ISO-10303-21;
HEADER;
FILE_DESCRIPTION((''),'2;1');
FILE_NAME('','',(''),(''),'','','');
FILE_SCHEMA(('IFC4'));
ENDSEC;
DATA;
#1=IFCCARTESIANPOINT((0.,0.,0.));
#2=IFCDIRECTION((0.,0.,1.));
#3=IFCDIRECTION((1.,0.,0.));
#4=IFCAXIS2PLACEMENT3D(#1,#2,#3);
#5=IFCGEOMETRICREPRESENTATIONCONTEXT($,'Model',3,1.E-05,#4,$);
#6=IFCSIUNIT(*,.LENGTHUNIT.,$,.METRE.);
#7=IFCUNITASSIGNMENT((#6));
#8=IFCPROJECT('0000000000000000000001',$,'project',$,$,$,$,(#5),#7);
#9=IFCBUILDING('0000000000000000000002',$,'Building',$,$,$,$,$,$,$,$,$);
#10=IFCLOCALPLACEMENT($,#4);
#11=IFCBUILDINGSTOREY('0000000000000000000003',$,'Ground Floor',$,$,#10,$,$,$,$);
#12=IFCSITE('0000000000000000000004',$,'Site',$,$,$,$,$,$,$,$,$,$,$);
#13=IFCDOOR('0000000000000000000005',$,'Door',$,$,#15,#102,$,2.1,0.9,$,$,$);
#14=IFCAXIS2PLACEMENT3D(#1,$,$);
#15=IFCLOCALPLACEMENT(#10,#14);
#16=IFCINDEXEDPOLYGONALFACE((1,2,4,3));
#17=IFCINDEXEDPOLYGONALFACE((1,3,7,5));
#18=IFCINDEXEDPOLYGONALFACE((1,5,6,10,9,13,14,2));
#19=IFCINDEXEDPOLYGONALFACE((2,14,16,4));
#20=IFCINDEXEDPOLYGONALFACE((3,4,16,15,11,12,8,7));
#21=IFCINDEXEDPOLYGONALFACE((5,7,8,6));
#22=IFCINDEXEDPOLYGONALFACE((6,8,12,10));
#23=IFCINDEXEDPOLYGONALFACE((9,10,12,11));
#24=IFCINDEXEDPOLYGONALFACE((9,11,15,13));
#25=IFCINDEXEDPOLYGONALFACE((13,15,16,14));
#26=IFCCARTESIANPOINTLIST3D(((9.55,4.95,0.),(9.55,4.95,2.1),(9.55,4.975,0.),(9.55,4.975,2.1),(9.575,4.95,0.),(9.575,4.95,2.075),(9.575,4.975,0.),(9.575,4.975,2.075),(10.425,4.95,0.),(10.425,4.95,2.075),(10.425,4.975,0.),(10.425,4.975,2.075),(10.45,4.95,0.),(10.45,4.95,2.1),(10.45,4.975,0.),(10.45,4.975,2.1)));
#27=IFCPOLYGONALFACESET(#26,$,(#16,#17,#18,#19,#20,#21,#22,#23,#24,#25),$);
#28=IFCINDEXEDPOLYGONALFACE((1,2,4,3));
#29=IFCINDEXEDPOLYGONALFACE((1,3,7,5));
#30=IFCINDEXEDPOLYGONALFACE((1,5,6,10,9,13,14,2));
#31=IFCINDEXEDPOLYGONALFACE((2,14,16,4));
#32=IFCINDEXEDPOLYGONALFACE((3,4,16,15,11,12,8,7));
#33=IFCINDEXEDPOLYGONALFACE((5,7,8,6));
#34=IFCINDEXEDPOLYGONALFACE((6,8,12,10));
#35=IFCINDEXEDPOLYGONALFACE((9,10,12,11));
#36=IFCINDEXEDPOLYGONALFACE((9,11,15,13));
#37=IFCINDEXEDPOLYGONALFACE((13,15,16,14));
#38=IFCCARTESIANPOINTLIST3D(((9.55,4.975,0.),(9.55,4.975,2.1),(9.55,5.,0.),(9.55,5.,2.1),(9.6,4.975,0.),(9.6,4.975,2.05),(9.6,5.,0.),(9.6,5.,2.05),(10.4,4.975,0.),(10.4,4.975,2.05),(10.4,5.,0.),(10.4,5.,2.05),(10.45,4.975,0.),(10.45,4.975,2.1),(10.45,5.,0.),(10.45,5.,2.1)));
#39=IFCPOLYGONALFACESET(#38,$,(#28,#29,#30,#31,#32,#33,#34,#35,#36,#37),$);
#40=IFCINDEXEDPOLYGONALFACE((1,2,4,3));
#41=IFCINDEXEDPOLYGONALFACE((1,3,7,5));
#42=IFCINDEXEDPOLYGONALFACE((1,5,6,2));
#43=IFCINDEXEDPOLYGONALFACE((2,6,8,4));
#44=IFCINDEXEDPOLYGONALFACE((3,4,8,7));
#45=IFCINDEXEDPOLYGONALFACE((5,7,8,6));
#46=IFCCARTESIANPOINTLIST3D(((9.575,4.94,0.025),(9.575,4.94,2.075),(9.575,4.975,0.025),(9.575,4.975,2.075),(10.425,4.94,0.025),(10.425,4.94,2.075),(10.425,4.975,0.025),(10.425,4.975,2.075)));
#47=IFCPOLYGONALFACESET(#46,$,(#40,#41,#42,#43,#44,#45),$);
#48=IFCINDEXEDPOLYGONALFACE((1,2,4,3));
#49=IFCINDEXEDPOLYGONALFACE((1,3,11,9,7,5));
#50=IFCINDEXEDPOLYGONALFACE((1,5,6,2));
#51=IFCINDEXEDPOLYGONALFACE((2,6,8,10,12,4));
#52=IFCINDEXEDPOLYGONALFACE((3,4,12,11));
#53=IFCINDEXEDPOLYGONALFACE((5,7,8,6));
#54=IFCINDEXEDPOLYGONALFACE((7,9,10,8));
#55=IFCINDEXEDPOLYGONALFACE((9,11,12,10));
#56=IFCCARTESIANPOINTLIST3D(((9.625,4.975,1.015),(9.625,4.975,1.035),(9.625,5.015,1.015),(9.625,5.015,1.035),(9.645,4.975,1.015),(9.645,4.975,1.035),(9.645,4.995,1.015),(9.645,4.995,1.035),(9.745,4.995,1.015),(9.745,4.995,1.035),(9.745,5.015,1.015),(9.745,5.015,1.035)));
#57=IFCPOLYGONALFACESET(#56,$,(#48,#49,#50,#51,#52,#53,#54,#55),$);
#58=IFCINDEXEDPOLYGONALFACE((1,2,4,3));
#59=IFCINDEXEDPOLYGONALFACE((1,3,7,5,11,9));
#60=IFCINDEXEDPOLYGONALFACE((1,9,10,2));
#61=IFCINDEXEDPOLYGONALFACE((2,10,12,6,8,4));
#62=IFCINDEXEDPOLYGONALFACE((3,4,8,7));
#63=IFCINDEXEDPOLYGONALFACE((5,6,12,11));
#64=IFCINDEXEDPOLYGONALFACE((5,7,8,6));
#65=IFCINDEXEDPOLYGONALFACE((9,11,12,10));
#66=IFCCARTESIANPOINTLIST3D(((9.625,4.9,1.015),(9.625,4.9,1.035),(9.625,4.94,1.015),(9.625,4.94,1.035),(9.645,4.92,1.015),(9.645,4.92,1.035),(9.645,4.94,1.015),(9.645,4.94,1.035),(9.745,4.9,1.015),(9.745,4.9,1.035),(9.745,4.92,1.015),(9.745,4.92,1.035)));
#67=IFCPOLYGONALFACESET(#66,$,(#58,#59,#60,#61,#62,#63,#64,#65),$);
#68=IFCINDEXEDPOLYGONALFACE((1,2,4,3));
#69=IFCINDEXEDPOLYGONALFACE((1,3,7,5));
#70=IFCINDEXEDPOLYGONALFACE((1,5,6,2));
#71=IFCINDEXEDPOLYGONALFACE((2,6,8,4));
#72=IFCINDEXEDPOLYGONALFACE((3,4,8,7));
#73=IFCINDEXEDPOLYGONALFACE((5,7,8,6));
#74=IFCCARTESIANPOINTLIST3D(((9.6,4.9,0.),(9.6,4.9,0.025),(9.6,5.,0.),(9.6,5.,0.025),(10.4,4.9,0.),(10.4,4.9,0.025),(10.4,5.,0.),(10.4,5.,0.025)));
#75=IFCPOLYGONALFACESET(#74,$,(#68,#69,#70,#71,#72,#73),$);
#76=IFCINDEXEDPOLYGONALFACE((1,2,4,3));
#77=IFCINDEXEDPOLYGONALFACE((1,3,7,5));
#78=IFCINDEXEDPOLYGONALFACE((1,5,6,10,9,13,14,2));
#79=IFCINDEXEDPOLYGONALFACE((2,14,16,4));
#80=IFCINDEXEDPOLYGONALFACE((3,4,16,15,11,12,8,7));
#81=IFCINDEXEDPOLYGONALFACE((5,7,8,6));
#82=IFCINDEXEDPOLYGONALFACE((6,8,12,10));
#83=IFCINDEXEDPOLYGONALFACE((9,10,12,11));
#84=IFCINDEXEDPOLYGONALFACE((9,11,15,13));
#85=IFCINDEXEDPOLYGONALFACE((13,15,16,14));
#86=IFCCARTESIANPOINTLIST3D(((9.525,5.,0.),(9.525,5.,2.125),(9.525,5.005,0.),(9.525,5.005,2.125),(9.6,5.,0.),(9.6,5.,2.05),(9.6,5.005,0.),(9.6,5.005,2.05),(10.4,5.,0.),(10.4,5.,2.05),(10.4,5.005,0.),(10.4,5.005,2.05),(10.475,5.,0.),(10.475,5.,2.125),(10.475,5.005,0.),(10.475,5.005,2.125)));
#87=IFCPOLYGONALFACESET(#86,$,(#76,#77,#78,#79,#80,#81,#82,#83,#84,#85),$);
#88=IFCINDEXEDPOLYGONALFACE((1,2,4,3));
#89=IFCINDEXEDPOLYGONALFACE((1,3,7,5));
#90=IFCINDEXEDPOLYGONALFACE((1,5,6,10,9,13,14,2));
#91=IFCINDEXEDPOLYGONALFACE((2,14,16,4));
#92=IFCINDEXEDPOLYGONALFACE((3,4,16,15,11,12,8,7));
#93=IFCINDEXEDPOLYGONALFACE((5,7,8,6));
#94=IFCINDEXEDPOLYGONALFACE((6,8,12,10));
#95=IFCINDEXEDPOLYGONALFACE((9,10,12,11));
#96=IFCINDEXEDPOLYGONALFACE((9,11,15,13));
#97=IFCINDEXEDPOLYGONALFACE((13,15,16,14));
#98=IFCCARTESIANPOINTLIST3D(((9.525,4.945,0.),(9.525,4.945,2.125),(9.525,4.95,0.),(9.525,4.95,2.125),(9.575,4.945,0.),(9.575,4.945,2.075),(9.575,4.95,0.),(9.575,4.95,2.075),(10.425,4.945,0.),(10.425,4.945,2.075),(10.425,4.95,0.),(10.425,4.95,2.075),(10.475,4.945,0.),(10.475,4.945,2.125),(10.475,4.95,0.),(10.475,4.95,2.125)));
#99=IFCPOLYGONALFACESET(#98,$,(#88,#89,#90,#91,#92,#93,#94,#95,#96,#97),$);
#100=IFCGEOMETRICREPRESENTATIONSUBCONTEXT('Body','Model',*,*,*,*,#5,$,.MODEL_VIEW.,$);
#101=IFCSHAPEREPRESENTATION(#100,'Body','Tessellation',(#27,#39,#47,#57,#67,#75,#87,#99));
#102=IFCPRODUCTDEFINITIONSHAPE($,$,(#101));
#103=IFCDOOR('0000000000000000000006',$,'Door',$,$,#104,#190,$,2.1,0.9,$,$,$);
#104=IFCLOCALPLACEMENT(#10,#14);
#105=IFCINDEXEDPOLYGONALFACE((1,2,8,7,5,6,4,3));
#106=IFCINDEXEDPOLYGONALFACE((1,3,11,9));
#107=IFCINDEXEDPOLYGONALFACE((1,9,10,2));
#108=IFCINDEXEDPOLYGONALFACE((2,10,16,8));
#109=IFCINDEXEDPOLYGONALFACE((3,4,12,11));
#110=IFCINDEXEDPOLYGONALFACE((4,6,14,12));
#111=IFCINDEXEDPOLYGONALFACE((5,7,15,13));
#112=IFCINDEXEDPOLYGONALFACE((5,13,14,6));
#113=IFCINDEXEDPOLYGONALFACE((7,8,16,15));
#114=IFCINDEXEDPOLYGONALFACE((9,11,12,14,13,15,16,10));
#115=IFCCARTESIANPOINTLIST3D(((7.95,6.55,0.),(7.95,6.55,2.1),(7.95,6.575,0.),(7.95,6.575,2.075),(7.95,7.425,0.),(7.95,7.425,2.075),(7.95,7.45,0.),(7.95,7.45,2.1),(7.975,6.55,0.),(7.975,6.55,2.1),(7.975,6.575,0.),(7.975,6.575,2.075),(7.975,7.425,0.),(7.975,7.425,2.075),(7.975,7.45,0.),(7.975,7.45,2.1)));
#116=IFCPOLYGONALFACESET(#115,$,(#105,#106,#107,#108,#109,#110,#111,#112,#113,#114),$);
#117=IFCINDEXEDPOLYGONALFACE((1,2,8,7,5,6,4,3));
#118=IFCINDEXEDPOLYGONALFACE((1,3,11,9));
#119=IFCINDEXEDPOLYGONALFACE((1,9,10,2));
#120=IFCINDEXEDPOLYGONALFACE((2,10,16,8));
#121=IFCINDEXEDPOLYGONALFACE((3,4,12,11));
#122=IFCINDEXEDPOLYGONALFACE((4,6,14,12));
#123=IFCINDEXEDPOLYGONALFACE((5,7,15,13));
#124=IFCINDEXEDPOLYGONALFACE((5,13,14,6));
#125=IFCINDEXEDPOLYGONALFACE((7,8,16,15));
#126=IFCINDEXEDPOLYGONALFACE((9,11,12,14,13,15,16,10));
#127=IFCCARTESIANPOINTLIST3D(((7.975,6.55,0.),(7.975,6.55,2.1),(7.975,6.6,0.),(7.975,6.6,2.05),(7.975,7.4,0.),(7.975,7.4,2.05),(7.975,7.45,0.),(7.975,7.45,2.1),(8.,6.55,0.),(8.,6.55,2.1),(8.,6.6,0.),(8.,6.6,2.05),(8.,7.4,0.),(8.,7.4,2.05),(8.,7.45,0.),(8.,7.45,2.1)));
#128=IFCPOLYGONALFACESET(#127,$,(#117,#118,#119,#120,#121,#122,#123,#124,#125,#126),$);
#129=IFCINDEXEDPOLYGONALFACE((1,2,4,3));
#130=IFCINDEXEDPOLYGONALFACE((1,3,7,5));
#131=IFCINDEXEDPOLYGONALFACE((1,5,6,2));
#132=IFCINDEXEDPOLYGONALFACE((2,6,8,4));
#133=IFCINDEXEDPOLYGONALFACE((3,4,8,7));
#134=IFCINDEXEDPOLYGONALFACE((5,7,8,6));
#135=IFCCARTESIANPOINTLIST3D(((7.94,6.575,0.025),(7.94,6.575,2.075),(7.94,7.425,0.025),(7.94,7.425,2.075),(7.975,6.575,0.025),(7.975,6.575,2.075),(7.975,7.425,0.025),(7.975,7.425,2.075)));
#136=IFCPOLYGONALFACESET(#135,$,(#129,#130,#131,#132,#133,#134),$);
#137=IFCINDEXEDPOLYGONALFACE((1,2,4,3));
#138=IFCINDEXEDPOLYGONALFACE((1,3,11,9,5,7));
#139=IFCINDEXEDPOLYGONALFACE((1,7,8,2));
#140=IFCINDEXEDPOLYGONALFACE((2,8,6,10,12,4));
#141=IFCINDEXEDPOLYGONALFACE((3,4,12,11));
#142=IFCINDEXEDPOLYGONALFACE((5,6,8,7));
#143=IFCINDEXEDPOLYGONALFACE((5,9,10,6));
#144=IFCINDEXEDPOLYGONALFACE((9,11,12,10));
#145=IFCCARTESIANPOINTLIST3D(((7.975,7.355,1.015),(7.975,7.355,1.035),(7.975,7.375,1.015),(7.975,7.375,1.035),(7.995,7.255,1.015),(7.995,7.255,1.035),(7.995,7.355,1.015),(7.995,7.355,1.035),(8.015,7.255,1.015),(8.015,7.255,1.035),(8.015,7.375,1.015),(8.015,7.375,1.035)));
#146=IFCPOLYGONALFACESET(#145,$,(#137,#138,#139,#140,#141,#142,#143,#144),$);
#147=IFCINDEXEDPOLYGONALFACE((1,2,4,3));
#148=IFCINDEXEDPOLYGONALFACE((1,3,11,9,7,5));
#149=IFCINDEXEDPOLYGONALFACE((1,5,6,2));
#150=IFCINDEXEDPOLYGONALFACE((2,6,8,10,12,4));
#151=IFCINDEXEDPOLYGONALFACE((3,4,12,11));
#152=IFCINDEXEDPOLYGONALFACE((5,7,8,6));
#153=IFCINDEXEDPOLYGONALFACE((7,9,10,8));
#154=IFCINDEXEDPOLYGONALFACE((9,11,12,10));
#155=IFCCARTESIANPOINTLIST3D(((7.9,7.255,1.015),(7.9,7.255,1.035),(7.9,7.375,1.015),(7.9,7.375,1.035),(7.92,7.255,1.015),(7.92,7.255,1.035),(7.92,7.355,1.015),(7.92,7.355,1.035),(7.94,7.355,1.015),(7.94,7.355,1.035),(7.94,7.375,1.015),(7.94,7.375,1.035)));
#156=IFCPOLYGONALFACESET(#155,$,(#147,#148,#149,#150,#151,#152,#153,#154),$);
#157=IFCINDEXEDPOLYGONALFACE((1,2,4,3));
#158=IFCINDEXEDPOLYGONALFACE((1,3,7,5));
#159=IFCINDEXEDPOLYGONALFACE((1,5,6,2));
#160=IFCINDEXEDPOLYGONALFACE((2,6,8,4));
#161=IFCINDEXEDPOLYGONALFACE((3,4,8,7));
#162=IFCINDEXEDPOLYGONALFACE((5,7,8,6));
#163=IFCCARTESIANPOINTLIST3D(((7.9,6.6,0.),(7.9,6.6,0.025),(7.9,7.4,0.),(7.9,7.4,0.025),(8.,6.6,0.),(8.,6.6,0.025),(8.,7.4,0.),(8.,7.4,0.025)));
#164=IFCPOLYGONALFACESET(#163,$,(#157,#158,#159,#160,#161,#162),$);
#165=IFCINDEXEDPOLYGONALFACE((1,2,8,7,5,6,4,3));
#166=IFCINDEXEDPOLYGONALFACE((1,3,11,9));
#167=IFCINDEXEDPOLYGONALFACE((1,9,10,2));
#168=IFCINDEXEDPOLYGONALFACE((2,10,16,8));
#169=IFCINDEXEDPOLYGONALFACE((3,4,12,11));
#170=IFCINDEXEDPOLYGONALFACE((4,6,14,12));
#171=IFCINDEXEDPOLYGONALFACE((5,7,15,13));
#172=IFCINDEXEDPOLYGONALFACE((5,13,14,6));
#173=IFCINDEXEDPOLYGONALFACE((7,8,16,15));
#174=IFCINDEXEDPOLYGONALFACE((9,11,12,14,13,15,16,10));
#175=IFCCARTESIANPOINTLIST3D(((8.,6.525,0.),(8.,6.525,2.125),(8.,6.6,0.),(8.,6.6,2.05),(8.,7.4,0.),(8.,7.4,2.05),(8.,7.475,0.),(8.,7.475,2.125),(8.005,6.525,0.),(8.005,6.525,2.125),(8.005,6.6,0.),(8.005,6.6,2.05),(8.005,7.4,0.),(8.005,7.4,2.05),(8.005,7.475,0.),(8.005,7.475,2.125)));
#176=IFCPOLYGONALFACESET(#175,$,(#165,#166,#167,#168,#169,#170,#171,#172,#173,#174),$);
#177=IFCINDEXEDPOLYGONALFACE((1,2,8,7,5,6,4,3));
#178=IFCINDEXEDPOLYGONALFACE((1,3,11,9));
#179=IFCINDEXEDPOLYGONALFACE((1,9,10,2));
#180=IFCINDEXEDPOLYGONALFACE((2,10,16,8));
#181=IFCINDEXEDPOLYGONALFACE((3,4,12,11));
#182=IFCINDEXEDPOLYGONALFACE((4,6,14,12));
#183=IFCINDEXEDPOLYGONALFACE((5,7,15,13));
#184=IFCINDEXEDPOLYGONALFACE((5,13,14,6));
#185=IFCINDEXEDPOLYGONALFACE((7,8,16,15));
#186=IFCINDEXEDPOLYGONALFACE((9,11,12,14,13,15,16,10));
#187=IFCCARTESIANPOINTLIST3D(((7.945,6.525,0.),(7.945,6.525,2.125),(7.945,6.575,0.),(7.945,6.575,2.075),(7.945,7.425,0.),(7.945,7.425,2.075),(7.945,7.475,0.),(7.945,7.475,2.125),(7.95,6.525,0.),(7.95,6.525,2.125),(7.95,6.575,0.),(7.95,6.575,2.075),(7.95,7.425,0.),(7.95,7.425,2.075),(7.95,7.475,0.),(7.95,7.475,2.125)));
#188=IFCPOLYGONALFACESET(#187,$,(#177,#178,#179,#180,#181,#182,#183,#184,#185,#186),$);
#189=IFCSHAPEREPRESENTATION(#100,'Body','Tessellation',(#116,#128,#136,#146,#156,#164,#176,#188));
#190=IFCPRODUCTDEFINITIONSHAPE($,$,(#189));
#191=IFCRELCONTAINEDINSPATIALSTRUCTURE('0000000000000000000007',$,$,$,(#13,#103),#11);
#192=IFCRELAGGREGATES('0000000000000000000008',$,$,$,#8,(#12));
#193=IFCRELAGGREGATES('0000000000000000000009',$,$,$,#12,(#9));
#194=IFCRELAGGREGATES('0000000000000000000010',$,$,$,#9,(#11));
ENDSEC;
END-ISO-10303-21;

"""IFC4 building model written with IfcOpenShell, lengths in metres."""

from ifc_helpers import new_model, si_unit, frame, origin_with_axes, place, context, subcontext, project, spatial, line, indexed_curve, outline, extrude, element, save


model = new_model("IFC4")

# Units and contexts
model_context = context("Model", 3, precision=1e-05, world=origin_with_axes())
body_context = subcontext(model_context, "Body", "Model", "MODEL_VIEW")
ifc_project = project(units=[si_unit("LENGTHUNIT", "METRE")], contexts=[model_context])

# Site, building, storey
site = spatial("IfcSite", under=ifc_project, Name="Site")
building = spatial("IfcBuilding", under=site, Name="Building")
storey_placement = place(None, origin_with_axes())
storey = spatial("IfcBuildingStorey", under=building, at=storey_placement, Name="Ground Floor")

# Doors
door_1_placement = place(storey_placement, frame((10.45, 5.0, 0.0), z_axis=(0.0, 0.0, 1.0), x_axis=(-1.0, 0.0, 0.0)))
element("IfcDoor", 1, at=door_1_placement, inside=storey, Name="Door", OverallHeight=2.1, OverallWidth=0.9, context=body_context, shape_type="SweptSolid", body=[
    extrude(outline(indexed_curve([(0.0, 0.0), (0.0, 2.1), (0.9, 2.1), (0.9, 0.0), (0.875, 0.0), (0.875, 2.075), (0.025, 2.075), (0.025, 0.0)], segments=[line(1, 2, 3, 4, 5, 6, 7, 8, 1)])), frame((0.0, 0.025, 0.0), z_axis=(0.0, -1.0, 0.0), x_axis=(1.0, 0.0, 0.0)), (0.0, 0.0, -1.0), 0.025),
    extrude(outline(indexed_curve([(0.0, 0.0), (0.0, 2.1), (0.9, 2.1), (0.9, 0.0), (0.85, 0.0), (0.85, 2.05), (0.05, 2.05), (0.05, 0.0)], segments=[line(1, 2, 3, 4, 5, 6, 7, 8, 1)])), frame((0.0, 0.0, 0.0), z_axis=(0.0, -1.0, 0.0), x_axis=(1.0, 0.0, 0.0)), (0.0, 0.0, -1.0), 0.025),
    extrude(outline(indexed_curve([(0.0, 0.0), (0.85, 0.0), (0.85, 0.035), (0.0, 0.035)], segments=[line(1, 2, 3, 4, 1)])), frame((0.025, 0.025, 0.025), z_axis=(0.0, 0.0, 1.0), x_axis=(1.0, 0.0, 0.0)), (0.0, 0.0, 1.0), 2.05),
    extrude(outline(indexed_curve([(0.0, 0.0), (0.0, -0.04), (-0.12, -0.04), (-0.12, -0.02), (-0.02, -0.02), (-0.02, 0.0)], segments=[line(1, 2, 3, 4, 5, 6, 1)])), frame((0.825, 0.025, 1.015), z_axis=(0.0, 0.0, 1.0), x_axis=(1.0, 0.0, 0.0)), (0.0, 0.0, 1.0), 0.02),
    extrude(outline(indexed_curve([(0.0, 0.0), (0.0, 0.04), (-0.12, 0.04), (-0.12, 0.02), (-0.02, 0.02), (-0.02, 0.0)], segments=[line(1, 2, 3, 4, 5, 6, 1)])), frame((0.825, 0.06, 1.015), z_axis=(0.0, 0.0, 1.0), x_axis=(1.0, 0.0, 0.0)), (0.0, 0.0, 1.0), 0.02),
    extrude(outline(indexed_curve([(0.0, 0.0), (0.8, 0.0), (0.8, 0.1), (0.0, 0.1)], segments=[line(1, 2, 3, 4, 1)])), frame((0.05, 0.0, 0.0), z_axis=(0.0, 0.0, 1.0), x_axis=(1.0, 0.0, 0.0)), (0.0, 0.0, 1.0), 0.025),
    extrude(outline(indexed_curve([(0.0, 0.0), (0.0, 2.125), (0.95, 2.125), (0.95, 0.0), (0.875, 0.0), (0.875, 2.05), (0.075, 2.05), (0.075, 0.0)], segments=[line(1, 2, 3, 4, 5, 6, 7, 8, 1)])), frame((-0.025, -0.005, 0.0), z_axis=(0.0, -1.0, 0.0), x_axis=(1.0, 0.0, 0.0)), (0.0, 0.0, -1.0), 0.005),
    extrude(outline(indexed_curve([(0.0, 0.0), (0.0, 2.125), (0.95, 2.125), (0.95, 0.0), (0.9, 0.0), (0.9, 2.075), (0.05, 2.075), (0.05, 0.0)], segments=[line(1, 2, 3, 4, 5, 6, 7, 8, 1)])), frame((-0.025, 0.05, 0.0), z_axis=(0.0, -1.0, 0.0), x_axis=(1.0, 0.0, 0.0)), (0.0, 0.0, -1.0), 0.005),
])
door_2_placement = place(storey_placement, frame((8.0, 6.55, 0.0), z_axis=(0.0, 0.0, 1.0), x_axis=(0.0, 1.0, 0.0)))
element("IfcDoor", 2, at=door_2_placement, inside=storey, Name="Door", OverallHeight=2.1, OverallWidth=0.9, context=body_context, shape_type="SweptSolid", body=[
    extrude(outline(indexed_curve([(0.0, 0.0), (0.0, 2.1), (0.9, 2.1), (0.9, 0.0), (0.875, 0.0), (0.875, 2.075), (0.025, 2.075), (0.025, 0.0)], segments=[line(1, 2, 3, 4, 5, 6, 7, 8, 1)])), frame((0.0, 0.025, 0.0), z_axis=(0.0, -1.0, 0.0), x_axis=(1.0, 0.0, 0.0)), (0.0, 0.0, -1.0), 0.025),
    extrude(outline(indexed_curve([(0.0, 0.0), (0.0, 2.1), (0.9, 2.1), (0.9, 0.0), (0.85, 0.0), (0.85, 2.05), (0.05, 2.05), (0.05, 0.0)], segments=[line(1, 2, 3, 4, 5, 6, 7, 8, 1)])), frame((0.0, 0.0, 0.0), z_axis=(0.0, -1.0, 0.0), x_axis=(1.0, 0.0, 0.0)), (0.0, 0.0, -1.0), 0.025),
    extrude(outline(indexed_curve([(0.0, 0.0), (0.85, 0.0), (0.85, 0.035), (0.0, 0.035)], segments=[line(1, 2, 3, 4, 1)])), frame((0.025, 0.025, 0.025), z_axis=(0.0, 0.0, 1.0), x_axis=(1.0, 0.0, 0.0)), (0.0, 0.0, 1.0), 2.05),
    extrude(outline(indexed_curve([(0.0, 0.0), (0.0, -0.04), (-0.12, -0.04), (-0.12, -0.02), (-0.02, -0.02), (-0.02, 0.0)], segments=[line(1, 2, 3, 4, 5, 6, 1)])), frame((0.825, 0.025, 1.015), z_axis=(0.0, 0.0, 1.0), x_axis=(1.0, 0.0, 0.0)), (0.0, 0.0, 1.0), 0.02),
    extrude(outline(indexed_curve([(0.0, 0.0), (0.0, 0.04), (-0.12, 0.04), (-0.12, 0.02), (-0.02, 0.02), (-0.02, 0.0)], segments=[line(1, 2, 3, 4, 5, 6, 1)])), frame((0.825, 0.06, 1.015), z_axis=(0.0, 0.0, 1.0), x_axis=(1.0, 0.0, 0.0)), (0.0, 0.0, 1.0), 0.02),
    extrude(outline(indexed_curve([(0.0, 0.0), (0.8, 0.0), (0.8, 0.1), (0.0, 0.1)], segments=[line(1, 2, 3, 4, 1)])), frame((0.05, 0.0, 0.0), z_axis=(0.0, 0.0, 1.0), x_axis=(1.0, 0.0, 0.0)), (0.0, 0.0, 1.0), 0.025),
    extrude(outline(indexed_curve([(0.0, 0.0), (0.0, 2.125), (0.95, 2.125), (0.95, 0.0), (0.875, 0.0), (0.875, 2.05), (0.075, 2.05), (0.075, 0.0)], segments=[line(1, 2, 3, 4, 5, 6, 7, 8, 1)])), frame((-0.025, -0.005, 0.0), z_axis=(0.0, -1.0, 0.0), x_axis=(1.0, 0.0, 0.0)), (0.0, 0.0, -1.0), 0.005),
    extrude(outline(indexed_curve([(0.0, 0.0), (0.0, 2.125), (0.95, 2.125), (0.95, 0.0), (0.9, 0.0), (0.9, 2.075), (0.05, 2.075), (0.05, 0.0)], segments=[line(1, 2, 3, 4, 5, 6, 7, 8, 1)])), frame((-0.025, 0.05, 0.0), z_axis=(0.0, -1.0, 0.0), x_axis=(1.0, 0.0, 0.0)), (0.0, 0.0, -1.0), 0.005),
])

save(model, "model.ifc")
